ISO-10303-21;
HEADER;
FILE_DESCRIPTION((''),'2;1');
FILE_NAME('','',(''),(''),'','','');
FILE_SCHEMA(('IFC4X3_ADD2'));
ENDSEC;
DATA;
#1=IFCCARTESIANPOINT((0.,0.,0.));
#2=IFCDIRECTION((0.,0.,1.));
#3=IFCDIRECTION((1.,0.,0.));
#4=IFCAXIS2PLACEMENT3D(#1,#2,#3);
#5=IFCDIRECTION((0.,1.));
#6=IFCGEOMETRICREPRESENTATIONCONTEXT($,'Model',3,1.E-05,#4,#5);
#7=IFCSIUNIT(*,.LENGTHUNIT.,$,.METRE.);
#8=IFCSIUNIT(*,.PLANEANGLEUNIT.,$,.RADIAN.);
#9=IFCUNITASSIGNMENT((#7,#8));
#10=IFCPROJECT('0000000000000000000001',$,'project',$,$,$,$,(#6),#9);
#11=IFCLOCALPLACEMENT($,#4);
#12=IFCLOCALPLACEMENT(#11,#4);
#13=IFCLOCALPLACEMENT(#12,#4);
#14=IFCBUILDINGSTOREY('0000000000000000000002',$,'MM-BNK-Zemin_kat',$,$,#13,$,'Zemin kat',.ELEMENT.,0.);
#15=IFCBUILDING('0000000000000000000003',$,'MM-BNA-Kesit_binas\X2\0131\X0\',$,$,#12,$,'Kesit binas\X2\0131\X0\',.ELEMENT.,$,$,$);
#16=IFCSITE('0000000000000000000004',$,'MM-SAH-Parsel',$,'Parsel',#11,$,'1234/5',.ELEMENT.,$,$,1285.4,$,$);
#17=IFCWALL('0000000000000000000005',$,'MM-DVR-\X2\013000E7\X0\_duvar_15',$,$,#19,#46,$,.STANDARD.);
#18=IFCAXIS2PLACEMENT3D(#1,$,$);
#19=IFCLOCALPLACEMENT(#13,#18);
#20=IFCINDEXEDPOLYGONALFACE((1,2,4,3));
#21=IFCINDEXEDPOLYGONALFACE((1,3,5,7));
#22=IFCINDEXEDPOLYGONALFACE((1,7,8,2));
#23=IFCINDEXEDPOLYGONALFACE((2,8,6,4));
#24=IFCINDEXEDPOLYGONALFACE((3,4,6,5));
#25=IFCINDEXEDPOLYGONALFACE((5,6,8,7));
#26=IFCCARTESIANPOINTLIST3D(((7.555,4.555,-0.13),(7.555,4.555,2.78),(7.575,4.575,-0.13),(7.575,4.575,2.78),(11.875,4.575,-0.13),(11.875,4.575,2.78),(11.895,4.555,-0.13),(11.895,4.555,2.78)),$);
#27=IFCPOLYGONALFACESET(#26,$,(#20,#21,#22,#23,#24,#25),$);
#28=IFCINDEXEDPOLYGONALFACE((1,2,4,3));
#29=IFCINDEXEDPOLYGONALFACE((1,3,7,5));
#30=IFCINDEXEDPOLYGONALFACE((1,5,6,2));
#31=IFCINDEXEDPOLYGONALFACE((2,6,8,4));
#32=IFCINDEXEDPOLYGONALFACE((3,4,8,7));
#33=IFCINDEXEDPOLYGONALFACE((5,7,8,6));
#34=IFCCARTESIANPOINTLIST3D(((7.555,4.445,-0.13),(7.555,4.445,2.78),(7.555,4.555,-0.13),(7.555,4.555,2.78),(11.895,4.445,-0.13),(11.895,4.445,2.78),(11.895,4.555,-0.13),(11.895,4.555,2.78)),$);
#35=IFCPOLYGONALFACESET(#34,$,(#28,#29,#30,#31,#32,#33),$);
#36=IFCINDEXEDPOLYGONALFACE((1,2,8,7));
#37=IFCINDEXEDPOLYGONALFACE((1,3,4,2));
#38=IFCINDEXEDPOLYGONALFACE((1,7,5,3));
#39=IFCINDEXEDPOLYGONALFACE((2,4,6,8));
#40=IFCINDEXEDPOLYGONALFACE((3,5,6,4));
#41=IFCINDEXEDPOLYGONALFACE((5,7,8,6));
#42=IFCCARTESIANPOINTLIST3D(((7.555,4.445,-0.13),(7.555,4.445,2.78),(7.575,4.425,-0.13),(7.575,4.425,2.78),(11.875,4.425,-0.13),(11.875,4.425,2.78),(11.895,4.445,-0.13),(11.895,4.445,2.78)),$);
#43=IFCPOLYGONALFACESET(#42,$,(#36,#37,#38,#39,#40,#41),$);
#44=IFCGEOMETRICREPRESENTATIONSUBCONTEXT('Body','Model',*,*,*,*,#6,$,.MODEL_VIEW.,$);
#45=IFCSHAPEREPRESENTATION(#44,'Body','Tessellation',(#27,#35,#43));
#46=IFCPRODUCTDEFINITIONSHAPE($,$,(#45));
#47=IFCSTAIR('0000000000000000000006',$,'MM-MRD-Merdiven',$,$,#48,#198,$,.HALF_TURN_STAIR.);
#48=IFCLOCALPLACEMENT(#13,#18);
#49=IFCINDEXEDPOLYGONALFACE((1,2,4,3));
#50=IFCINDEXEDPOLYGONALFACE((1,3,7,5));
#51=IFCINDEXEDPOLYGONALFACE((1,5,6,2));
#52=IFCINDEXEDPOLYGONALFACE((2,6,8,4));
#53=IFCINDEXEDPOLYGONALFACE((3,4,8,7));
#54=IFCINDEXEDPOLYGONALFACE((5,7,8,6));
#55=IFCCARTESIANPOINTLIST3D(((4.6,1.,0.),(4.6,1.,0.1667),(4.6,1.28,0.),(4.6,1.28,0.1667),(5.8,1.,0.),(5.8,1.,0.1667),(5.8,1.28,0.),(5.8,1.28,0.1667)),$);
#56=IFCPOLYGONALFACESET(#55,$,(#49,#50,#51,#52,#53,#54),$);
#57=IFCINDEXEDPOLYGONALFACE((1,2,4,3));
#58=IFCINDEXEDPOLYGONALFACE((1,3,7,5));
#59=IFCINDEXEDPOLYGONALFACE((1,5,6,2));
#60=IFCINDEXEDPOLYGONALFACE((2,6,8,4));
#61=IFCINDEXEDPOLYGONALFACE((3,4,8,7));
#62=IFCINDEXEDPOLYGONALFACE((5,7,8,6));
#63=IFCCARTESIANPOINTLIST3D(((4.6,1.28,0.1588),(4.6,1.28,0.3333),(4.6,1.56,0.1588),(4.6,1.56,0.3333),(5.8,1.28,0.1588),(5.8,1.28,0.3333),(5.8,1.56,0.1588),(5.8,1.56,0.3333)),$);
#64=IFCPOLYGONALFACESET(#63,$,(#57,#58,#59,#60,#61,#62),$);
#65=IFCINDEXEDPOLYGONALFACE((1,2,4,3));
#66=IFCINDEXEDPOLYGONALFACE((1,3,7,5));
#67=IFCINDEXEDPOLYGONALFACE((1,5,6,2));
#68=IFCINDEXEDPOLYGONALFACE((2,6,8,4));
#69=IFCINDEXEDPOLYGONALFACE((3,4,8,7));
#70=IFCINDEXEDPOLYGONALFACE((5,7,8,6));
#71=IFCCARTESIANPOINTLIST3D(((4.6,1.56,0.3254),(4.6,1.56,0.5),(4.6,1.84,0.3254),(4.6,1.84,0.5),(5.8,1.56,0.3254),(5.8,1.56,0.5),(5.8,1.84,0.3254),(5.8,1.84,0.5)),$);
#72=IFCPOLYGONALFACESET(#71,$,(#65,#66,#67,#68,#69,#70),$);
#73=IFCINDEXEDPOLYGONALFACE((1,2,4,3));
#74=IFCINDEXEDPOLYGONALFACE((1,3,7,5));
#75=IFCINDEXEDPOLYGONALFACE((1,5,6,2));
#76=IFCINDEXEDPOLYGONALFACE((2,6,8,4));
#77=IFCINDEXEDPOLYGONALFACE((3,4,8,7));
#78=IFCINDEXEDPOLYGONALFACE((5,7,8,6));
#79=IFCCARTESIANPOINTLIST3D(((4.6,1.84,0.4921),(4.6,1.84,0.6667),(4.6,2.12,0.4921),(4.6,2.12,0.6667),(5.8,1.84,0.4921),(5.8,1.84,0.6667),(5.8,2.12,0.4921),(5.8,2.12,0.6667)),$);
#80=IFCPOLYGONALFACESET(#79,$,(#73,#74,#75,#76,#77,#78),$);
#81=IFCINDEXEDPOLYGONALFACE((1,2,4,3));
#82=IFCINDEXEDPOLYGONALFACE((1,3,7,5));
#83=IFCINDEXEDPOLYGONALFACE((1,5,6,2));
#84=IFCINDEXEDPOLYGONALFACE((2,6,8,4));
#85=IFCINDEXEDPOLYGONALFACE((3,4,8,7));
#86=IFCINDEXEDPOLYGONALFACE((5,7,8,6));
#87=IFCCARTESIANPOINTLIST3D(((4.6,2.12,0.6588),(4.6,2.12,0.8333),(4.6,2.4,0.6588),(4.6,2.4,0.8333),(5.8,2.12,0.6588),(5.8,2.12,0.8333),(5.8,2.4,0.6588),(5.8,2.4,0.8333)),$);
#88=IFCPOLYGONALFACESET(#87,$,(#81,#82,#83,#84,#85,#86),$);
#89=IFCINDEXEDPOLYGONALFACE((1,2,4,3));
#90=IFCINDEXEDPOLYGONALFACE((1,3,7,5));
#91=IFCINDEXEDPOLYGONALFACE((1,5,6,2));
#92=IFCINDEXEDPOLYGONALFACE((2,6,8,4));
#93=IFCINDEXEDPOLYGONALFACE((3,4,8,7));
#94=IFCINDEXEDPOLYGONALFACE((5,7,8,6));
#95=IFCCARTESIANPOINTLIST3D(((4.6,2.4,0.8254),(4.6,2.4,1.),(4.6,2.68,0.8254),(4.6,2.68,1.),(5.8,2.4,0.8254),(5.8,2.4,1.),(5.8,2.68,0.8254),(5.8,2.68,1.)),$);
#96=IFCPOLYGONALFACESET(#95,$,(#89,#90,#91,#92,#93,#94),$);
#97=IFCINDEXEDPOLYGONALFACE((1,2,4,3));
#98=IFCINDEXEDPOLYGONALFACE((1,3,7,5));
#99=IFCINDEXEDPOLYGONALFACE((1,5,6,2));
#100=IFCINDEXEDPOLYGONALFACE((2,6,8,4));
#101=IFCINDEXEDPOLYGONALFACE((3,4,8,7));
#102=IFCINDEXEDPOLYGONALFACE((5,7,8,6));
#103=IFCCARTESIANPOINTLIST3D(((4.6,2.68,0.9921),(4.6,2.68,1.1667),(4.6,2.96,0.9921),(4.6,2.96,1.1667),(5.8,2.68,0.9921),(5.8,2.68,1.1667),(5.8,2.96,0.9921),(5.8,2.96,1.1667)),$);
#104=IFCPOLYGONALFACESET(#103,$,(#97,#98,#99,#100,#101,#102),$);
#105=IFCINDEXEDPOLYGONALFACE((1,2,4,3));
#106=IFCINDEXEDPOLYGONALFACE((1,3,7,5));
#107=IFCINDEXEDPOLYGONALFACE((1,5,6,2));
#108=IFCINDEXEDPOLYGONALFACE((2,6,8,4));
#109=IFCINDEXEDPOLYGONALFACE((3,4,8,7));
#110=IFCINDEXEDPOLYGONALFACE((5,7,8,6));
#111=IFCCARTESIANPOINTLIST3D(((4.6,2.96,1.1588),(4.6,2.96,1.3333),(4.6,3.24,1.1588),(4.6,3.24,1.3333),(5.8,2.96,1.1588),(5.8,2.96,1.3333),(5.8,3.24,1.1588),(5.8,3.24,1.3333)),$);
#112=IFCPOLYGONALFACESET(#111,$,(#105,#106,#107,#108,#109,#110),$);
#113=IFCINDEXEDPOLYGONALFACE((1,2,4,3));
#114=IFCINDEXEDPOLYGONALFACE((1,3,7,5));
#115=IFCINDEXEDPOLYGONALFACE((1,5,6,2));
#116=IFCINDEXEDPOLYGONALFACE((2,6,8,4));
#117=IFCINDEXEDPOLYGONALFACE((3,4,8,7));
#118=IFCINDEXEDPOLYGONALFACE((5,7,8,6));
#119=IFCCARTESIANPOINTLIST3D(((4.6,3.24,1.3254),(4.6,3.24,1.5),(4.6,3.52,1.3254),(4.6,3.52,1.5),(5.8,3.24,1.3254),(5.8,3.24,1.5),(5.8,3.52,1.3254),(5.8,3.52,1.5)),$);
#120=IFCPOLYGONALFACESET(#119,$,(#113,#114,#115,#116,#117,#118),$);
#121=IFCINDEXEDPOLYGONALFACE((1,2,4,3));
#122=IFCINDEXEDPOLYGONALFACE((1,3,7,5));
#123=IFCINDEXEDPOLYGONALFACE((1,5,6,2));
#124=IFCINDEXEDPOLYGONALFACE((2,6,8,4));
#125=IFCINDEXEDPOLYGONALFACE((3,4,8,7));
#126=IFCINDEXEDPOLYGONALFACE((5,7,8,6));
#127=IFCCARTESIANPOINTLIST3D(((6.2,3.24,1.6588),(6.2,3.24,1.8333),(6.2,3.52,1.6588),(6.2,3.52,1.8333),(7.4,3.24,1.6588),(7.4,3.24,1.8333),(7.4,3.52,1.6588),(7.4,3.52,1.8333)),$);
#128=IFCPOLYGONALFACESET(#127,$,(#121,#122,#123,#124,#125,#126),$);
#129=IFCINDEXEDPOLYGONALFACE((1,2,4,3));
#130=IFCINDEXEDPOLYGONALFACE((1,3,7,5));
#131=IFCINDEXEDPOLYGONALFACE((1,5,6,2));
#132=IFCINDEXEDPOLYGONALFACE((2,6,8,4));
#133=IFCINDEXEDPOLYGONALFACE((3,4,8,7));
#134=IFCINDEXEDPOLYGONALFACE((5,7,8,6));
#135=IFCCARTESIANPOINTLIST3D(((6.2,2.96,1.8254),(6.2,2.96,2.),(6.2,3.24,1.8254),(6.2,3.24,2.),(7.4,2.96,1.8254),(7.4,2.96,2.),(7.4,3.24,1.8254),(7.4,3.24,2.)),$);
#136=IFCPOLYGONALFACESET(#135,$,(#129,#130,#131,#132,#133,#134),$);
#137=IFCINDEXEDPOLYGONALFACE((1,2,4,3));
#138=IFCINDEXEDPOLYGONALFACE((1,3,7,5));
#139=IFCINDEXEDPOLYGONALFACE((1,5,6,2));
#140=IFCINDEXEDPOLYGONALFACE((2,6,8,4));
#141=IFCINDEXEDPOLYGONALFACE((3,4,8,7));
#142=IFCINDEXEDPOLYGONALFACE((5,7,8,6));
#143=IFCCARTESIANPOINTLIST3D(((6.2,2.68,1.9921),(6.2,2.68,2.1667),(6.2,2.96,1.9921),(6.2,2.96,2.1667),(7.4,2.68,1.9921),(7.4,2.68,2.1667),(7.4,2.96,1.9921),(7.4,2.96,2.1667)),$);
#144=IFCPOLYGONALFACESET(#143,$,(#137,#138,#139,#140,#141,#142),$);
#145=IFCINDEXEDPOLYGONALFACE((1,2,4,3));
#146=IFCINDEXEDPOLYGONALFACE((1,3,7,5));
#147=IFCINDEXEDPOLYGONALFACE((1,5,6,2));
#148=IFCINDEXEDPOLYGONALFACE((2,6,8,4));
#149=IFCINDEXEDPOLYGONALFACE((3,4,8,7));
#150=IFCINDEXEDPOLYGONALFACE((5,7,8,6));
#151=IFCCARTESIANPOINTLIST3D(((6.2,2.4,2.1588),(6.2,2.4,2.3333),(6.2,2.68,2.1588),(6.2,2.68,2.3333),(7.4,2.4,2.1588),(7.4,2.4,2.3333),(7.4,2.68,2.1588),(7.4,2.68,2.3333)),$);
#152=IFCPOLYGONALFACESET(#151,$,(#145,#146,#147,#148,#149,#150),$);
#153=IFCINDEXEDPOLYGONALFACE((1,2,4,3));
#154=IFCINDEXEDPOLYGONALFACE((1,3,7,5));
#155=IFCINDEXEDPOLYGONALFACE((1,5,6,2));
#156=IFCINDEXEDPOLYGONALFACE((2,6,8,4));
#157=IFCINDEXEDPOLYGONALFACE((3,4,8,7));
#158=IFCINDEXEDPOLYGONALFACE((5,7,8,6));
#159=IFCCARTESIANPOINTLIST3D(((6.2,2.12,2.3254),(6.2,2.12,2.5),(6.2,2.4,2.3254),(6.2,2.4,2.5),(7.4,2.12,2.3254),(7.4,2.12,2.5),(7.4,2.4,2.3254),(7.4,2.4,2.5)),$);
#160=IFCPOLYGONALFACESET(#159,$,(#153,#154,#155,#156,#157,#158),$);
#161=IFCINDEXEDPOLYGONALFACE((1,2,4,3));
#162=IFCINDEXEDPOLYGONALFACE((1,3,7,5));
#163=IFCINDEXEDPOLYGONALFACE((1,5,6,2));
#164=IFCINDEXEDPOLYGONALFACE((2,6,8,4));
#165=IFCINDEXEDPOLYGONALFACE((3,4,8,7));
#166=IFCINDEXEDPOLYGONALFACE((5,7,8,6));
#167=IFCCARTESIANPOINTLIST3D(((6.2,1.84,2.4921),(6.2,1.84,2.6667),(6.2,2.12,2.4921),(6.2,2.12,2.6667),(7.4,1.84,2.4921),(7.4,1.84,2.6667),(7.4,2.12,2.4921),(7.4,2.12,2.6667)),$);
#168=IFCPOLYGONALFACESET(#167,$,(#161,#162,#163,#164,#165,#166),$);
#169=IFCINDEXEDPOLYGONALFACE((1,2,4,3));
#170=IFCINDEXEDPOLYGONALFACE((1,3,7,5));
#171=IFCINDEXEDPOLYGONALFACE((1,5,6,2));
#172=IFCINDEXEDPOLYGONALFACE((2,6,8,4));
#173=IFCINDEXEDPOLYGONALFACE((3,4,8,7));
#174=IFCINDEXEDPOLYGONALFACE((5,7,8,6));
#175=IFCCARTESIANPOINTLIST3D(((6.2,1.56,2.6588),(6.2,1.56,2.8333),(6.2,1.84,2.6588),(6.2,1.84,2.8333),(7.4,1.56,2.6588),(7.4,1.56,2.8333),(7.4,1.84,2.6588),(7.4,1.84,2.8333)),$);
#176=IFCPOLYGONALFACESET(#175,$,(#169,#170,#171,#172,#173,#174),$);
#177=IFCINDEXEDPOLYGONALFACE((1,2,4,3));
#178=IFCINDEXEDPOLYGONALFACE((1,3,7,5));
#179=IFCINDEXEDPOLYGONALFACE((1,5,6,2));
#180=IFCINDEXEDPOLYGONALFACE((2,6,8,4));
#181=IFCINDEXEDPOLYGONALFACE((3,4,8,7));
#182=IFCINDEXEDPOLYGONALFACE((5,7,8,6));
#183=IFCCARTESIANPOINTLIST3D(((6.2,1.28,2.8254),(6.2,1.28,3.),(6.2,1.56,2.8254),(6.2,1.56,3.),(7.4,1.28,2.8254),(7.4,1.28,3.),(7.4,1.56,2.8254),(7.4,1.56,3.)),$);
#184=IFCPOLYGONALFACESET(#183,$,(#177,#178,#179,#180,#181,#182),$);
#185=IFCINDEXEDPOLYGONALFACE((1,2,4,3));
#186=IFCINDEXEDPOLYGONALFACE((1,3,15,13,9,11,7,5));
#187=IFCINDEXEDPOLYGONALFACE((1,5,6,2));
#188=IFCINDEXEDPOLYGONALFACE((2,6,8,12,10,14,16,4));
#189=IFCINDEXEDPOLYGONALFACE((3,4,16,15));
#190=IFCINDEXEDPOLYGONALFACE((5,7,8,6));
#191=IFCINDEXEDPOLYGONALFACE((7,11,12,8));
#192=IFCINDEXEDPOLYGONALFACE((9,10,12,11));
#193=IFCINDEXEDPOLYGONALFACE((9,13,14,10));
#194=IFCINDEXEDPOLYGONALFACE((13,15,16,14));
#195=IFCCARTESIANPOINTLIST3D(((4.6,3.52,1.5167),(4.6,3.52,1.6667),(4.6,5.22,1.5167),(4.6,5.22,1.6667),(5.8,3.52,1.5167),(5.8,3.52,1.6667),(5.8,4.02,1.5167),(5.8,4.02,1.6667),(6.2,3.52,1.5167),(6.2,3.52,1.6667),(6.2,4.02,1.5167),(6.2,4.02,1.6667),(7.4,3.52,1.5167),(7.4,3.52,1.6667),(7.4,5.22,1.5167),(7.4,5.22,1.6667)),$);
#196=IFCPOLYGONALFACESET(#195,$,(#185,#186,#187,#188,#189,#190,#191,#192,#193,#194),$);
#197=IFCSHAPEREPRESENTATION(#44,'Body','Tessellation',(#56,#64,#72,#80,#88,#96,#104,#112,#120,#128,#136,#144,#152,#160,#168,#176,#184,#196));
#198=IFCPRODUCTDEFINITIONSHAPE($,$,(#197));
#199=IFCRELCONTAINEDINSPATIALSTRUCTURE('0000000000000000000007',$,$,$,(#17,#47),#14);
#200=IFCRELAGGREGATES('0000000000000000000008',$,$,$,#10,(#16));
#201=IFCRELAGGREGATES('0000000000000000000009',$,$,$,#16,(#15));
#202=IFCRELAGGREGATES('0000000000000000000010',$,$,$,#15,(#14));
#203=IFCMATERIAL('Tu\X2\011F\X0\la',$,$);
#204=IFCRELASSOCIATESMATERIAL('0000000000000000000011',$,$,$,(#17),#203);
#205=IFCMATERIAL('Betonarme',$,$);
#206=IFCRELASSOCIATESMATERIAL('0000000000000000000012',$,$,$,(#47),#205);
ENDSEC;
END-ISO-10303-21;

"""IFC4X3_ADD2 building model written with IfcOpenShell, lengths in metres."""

from ifc_helpers import new_model, si_unit, direction, frame, origin, origin_with_axes, place, context, subcontext, project, spatial, polyline, outline, extrude, material, element, save


model = new_model("IFC4X3_ADD2")

# Units and contexts
model_context = context("Model", 3, precision=1e-05, world=origin_with_axes(), true_north=direction((0.0, 1.0)))
body_context = subcontext(model_context, "Body", "Model", "MODEL_VIEW")
ifc_project = project(units=[si_unit("LENGTHUNIT", "METRE"), si_unit("PLANEANGLEUNIT", "RADIAN")], contexts=[model_context])

# Site, building, storey
site_placement = place(None, origin_with_axes())
site = spatial("IfcSite", under=ifc_project, at=site_placement, Name="MM-SAH-Parsel", ObjectType="Parsel", LongName="1234/5", CompositionType="ELEMENT", RefElevation=1285.4)
building_placement = place(site_placement, origin_with_axes())
building = spatial("IfcBuilding", under=site, at=building_placement, Name="MM-BNA-Kesit_binası", LongName="Kesit binası", CompositionType="ELEMENT")
storey_placement = place(building_placement, origin_with_axes())
storey = spatial("IfcBuildingStorey", under=building, at=storey_placement, Name="MM-BNK-Zemin_kat", LongName="Zemin kat", CompositionType="ELEMENT", Elevation=0.0)

# Shared definitions
ifc_material_1 = material(Name="Betonarme")

# Shared definitions
ifc_material_2 = material(Name="Tuğla")

# Wall
wall_1_placement = place(storey_placement, origin_with_axes())
element("IfcWall", 1, at=wall_1_placement, inside=storey, material=ifc_material_2, Name="MM-DVR-İç_duvar_15", PredefinedType="STANDARD", context=body_context, shape_type="SweptSolid", body=[
    extrude(outline(polyline([(7.575, 4.575), (11.875, 4.575), (11.895, 4.555), (7.555, 4.555), (7.575, 4.575)])), frame((0.0, 0.0, -0.13)), (0.0, 0.0, 1.0), 2.91),
    extrude(outline(polyline([(7.555, 4.555), (11.895, 4.555), (11.895, 4.445), (7.555, 4.445), (7.555, 4.555)])), frame((0.0, 0.0, -0.13)), (0.0, 0.0, 1.0), 2.91),
    extrude(outline(polyline([(7.555, 4.445), (11.895, 4.445), (11.875, 4.425), (7.575, 4.425), (7.555, 4.445)])), frame((0.0, 0.0, -0.13)), (0.0, 0.0, 1.0), 2.91),
])

# Stair
stair_placement = place(storey_placement, origin_with_axes())
element("IfcStair", 2, at=stair_placement, inside=storey, material=ifc_material_1, Name="MM-MRD-Merdiven", PredefinedType="HALF_TURN_STAIR", context=body_context, shape_type="SweptSolid", body=[
    extrude(outline(polyline([(5.8, 1.0), (5.8, 1.28), (4.6, 1.28), (4.6, 1.0), (5.8, 1.0)])), origin(), (0.0, 0.0, 1.0), 0.1667),
    extrude(outline(polyline([(5.8, 1.28), (5.8, 1.56), (4.6, 1.56), (4.6, 1.28), (5.8, 1.28)])), frame((0.0, 0.0, 0.1588)), (0.0, 0.0, 1.0), 0.1746),
    extrude(outline(polyline([(5.8, 1.56), (5.8, 1.84), (4.6, 1.84), (4.6, 1.56), (5.8, 1.56)])), frame((0.0, 0.0, 0.3254)), (0.0, 0.0, 1.0), 0.1746),
    extrude(outline(polyline([(5.8, 1.84), (5.8, 2.12), (4.6, 2.12), (4.6, 1.84), (5.8, 1.84)])), frame((0.0, 0.0, 0.4921)), (0.0, 0.0, 1.0), 0.1746),
    extrude(outline(polyline([(5.8, 2.12), (5.8, 2.4), (4.6, 2.4), (4.6, 2.12), (5.8, 2.12)])), frame((0.0, 0.0, 0.6588)), (0.0, 0.0, 1.0), 0.1746),
    extrude(outline(polyline([(5.8, 2.4), (5.8, 2.68), (4.6, 2.68), (4.6, 2.4), (5.8, 2.4)])), frame((0.0, 0.0, 0.8254)), (0.0, 0.0, 1.0), 0.1746),
    extrude(outline(polyline([(5.8, 2.68), (5.8, 2.96), (4.6, 2.96), (4.6, 2.68), (5.8, 2.68)])), frame((0.0, 0.0, 0.9921)), (0.0, 0.0, 1.0), 0.1746),
    extrude(outline(polyline([(5.8, 2.96), (5.8, 3.24), (4.6, 3.24), (4.6, 2.96), (5.8, 2.96)])), frame((0.0, 0.0, 1.1588)), (0.0, 0.0, 1.0), 0.1746),
    extrude(outline(polyline([(5.8, 3.24), (5.8, 3.52), (4.6, 3.52), (4.6, 3.24), (5.8, 3.24)])), frame((0.0, 0.0, 1.3254)), (0.0, 0.0, 1.0), 0.1746),
    extrude(outline(polyline([(6.2, 3.52), (6.2, 3.24), (7.4, 3.24), (7.4, 3.52), (6.2, 3.52)])), frame((0.0, 0.0, 1.6588)), (0.0, 0.0, 1.0), 0.1746),
    extrude(outline(polyline([(6.2, 3.24), (6.2, 2.96), (7.4, 2.96), (7.4, 3.24), (6.2, 3.24)])), frame((0.0, 0.0, 1.8254)), (0.0, 0.0, 1.0), 0.1746),
    extrude(outline(polyline([(6.2, 2.96), (6.2, 2.68), (7.4, 2.68), (7.4, 2.96), (6.2, 2.96)])), frame((0.0, 0.0, 1.9921)), (0.0, 0.0, 1.0), 0.1746),
    extrude(outline(polyline([(6.2, 2.68), (6.2, 2.4), (7.4, 2.4), (7.4, 2.68), (6.2, 2.68)])), frame((0.0, 0.0, 2.1588)), (0.0, 0.0, 1.0), 0.1746),
    extrude(outline(polyline([(6.2, 2.4), (6.2, 2.12), (7.4, 2.12), (7.4, 2.4), (6.2, 2.4)])), frame((0.0, 0.0, 2.3254)), (0.0, 0.0, 1.0), 0.1746),
    extrude(outline(polyline([(6.2, 2.12), (6.2, 1.84), (7.4, 1.84), (7.4, 2.12), (6.2, 2.12)])), frame((0.0, 0.0, 2.4921)), (0.0, 0.0, 1.0), 0.1746),
    extrude(outline(polyline([(6.2, 1.84), (6.2, 1.56), (7.4, 1.56), (7.4, 1.84), (6.2, 1.84)])), frame((0.0, 0.0, 2.6588)), (0.0, 0.0, 1.0), 0.1746),
    extrude(outline(polyline([(6.2, 1.56), (6.2, 1.28), (7.4, 1.28), (7.4, 1.56), (6.2, 1.56)])), frame((0.0, 0.0, 2.8254)), (0.0, 0.0, 1.0), 0.1746),
    extrude(outline(polyline([(4.6, 3.52), (4.6, 5.22), (7.4, 5.22), (7.4, 3.52), (6.2, 3.52), (6.2, 4.02), (5.8, 4.02), (5.8, 3.52), (4.6, 3.52)])), frame((0.0, 0.0, 1.5167)), (0.0, 0.0, 1.0), 0.15),
])

save(model, "model.ifc")
